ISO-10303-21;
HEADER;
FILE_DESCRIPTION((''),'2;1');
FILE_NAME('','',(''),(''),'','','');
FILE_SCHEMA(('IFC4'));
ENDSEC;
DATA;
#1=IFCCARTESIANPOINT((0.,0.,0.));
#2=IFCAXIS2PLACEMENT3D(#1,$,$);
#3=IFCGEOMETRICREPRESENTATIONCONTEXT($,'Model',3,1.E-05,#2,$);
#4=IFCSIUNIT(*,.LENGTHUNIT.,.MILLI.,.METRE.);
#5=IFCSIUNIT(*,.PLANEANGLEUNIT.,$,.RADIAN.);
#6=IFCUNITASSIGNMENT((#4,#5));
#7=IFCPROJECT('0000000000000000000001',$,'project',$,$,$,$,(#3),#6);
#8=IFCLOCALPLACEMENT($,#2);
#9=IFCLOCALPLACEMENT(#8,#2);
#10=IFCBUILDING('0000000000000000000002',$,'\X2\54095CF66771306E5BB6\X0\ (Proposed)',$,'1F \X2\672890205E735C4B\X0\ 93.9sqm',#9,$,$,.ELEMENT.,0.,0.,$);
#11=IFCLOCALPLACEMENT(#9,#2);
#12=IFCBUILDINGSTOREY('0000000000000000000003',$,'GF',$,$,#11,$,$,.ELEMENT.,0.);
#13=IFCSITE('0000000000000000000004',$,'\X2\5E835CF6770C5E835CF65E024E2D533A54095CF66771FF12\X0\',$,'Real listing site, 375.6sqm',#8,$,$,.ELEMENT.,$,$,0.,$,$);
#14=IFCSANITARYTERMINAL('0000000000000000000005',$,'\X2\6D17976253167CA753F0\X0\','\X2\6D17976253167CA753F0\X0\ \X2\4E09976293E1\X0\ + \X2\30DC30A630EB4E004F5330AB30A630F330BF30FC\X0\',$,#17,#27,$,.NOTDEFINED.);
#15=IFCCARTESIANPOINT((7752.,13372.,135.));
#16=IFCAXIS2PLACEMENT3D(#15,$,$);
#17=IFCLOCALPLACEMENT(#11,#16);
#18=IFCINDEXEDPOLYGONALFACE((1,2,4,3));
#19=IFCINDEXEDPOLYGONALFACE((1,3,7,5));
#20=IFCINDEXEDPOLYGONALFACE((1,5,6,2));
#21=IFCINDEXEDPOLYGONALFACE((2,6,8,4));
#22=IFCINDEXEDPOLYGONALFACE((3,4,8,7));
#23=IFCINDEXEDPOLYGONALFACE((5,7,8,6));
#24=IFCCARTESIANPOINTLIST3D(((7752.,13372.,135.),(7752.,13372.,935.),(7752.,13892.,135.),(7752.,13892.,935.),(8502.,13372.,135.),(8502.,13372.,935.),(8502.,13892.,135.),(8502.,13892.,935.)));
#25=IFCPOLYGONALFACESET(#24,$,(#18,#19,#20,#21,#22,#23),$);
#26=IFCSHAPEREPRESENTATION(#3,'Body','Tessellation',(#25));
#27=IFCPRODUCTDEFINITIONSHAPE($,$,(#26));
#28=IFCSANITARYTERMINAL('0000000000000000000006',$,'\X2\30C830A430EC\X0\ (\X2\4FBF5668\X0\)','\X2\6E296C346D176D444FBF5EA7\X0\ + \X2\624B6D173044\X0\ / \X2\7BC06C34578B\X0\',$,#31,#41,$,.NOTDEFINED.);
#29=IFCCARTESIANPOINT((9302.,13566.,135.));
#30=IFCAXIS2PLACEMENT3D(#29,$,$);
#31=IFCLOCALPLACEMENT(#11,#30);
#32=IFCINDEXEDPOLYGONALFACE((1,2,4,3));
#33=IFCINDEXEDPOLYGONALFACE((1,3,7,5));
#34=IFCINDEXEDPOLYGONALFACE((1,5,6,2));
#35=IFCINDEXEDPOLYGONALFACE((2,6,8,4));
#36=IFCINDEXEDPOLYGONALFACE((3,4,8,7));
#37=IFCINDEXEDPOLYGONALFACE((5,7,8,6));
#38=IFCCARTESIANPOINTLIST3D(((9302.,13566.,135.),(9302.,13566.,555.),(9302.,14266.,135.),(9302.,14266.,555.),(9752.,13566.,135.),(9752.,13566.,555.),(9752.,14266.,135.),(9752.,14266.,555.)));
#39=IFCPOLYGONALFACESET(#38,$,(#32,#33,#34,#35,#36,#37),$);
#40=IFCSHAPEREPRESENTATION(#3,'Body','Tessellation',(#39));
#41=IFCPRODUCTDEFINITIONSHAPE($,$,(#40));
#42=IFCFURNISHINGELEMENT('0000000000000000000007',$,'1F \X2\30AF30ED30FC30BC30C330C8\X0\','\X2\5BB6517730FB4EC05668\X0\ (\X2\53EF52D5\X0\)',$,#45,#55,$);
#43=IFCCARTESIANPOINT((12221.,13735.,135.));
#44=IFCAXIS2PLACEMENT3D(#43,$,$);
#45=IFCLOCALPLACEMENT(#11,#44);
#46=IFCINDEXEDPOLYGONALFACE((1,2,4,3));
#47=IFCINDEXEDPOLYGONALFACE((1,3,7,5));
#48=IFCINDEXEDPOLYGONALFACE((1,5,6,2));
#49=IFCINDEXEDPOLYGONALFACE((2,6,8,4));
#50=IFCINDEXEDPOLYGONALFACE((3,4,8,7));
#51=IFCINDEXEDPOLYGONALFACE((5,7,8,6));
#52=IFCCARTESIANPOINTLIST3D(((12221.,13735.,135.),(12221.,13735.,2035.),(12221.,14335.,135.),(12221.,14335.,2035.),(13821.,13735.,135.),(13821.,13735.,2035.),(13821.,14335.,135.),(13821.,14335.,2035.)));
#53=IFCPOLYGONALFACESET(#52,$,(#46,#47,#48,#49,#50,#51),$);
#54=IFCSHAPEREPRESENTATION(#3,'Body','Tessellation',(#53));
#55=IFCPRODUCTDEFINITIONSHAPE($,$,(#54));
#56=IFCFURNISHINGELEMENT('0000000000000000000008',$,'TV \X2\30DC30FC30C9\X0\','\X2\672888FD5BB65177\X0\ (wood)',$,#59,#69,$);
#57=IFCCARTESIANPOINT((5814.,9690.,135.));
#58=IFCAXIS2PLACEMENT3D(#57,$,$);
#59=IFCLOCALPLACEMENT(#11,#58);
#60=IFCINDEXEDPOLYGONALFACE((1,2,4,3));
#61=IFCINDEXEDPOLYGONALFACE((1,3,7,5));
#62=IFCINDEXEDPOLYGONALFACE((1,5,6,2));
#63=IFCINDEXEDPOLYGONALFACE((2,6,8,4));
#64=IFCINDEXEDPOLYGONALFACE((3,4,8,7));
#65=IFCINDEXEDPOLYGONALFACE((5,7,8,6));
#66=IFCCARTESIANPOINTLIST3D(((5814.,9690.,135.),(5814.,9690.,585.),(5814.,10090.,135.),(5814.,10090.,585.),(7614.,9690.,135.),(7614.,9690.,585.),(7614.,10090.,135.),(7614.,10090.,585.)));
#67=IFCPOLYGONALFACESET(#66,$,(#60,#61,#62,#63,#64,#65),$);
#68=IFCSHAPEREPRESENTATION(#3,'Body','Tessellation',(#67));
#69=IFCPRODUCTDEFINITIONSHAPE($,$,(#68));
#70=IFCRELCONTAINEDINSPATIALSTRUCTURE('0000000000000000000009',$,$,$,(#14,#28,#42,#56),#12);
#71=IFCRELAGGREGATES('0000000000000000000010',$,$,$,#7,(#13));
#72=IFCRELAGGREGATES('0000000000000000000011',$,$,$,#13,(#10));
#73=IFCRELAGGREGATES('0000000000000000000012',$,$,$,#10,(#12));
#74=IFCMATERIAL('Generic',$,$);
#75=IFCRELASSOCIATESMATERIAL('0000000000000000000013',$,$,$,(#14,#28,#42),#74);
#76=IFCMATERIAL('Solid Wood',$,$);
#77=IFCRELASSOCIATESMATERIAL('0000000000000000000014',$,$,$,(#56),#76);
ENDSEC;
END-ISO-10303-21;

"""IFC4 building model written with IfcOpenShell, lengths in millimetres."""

from ifc_helpers import new_model, si_unit, frame, frame_2d, origin, place, context, project, spatial, rectangle, extrude, material, element, save


model = new_model("IFC4")

# Units and contexts
model_context = context("Model", 3, precision=1e-05, world=origin())
ifc_project = project(units=[si_unit("LENGTHUNIT", "METRE", prefix="MILLI"), si_unit("PLANEANGLEUNIT", "RADIAN")], contexts=[model_context])

# Site, building, storey
site_placement = place(None, origin())
site = spatial("IfcSite", under=ifc_project, at=site_placement, Name="広島県広島市中区吉島東２", ObjectType="Real listing site, 375.6sqm", CompositionType="ELEMENT", RefElevation=0.0)
building_placement = place(site_placement, origin())
building = spatial("IfcBuilding", under=site, at=building_placement, Name="吉島東の家 (Proposed)", ObjectType="1F 木造平屋 93.9sqm", CompositionType="ELEMENT", ElevationOfRefHeight=0.0, ElevationOfTerrain=0.0)
storey_placement = place(building_placement, origin())
storey = spatial("IfcBuildingStorey", under=building, at=storey_placement, Name="GF", CompositionType="ELEMENT", Elevation=0.0)

# Shared definitions
ifc_material_1 = material(Name="Solid Wood")

# Sanitary terminals
ifc_material_2 = material(Name="Generic")
sanitary_terminal_1_placement = place(storey_placement, frame((7752.0, 13372.0, 135.0)))
element("IfcSanitaryTerminal", 1, at=sanitary_terminal_1_placement, inside=storey, material=ifc_material_2, Name="洗面化粧台", Description="洗面化粧台 三面鏡 + ボウル一体カウンター", PredefinedType="NOTDEFINED", context=model_context, shape_type="SweptSolid", body=[
    extrude(rectangle(XDim=750.0, YDim=520.0, at=frame_2d((375.0, 260.0))), frame((7752.0, 13372.0, 135.0)), (0.0, 0.0, 1.0), 800.0),
])
sanitary_terminal_2_placement = place(storey_placement, frame((9302.0, 13566.0, 135.0)))
element("IfcSanitaryTerminal", 2, at=sanitary_terminal_2_placement, inside=storey, material=ifc_material_2, Name="トイレ (便器)", Description="温水洗浄便座 + 手洗い / 節水型", PredefinedType="NOTDEFINED", context=model_context, shape_type="SweptSolid", body=[
    extrude(rectangle(XDim=450.0, YDim=700.0, at=frame_2d((225.0, 350.0))), frame((9302.0, 13566.0, 135.0)), (0.0, 0.0, 1.0), 420.0),
])

# Furnishing elements
furnishing_1_placement = place(storey_placement, frame((12221.0, 13735.0, 135.0)))
element("IfcFurnishingElement", 3, at=furnishing_1_placement, inside=storey, material=ifc_material_2, Name="1F クローゼット", Description="家具・什器 (可動)", context=model_context, shape_type="SweptSolid", body=[
    extrude(rectangle(XDim=1600.0, YDim=600.0, at=frame_2d((800.0, 300.0))), frame((12221.0, 13735.0, 135.0)), (0.0, 0.0, 1.0), 1900.0),
])
furnishing_2_placement = place(storey_placement, frame((5814.0, 9690.0, 135.0)))
element("IfcFurnishingElement", 4, at=furnishing_2_placement, inside=storey, material=ifc_material_1, Name="TV ボード", Description="木製家具 (wood)", context=model_context, shape_type="SweptSolid", body=[
    extrude(rectangle(XDim=1800.0, YDim=400.0, at=frame_2d((900.0, 200.0))), frame((5814.0, 9690.0, 135.0)), (0.0, 0.0, 1.0), 450.0),
])

save(model, "model.ifc")
